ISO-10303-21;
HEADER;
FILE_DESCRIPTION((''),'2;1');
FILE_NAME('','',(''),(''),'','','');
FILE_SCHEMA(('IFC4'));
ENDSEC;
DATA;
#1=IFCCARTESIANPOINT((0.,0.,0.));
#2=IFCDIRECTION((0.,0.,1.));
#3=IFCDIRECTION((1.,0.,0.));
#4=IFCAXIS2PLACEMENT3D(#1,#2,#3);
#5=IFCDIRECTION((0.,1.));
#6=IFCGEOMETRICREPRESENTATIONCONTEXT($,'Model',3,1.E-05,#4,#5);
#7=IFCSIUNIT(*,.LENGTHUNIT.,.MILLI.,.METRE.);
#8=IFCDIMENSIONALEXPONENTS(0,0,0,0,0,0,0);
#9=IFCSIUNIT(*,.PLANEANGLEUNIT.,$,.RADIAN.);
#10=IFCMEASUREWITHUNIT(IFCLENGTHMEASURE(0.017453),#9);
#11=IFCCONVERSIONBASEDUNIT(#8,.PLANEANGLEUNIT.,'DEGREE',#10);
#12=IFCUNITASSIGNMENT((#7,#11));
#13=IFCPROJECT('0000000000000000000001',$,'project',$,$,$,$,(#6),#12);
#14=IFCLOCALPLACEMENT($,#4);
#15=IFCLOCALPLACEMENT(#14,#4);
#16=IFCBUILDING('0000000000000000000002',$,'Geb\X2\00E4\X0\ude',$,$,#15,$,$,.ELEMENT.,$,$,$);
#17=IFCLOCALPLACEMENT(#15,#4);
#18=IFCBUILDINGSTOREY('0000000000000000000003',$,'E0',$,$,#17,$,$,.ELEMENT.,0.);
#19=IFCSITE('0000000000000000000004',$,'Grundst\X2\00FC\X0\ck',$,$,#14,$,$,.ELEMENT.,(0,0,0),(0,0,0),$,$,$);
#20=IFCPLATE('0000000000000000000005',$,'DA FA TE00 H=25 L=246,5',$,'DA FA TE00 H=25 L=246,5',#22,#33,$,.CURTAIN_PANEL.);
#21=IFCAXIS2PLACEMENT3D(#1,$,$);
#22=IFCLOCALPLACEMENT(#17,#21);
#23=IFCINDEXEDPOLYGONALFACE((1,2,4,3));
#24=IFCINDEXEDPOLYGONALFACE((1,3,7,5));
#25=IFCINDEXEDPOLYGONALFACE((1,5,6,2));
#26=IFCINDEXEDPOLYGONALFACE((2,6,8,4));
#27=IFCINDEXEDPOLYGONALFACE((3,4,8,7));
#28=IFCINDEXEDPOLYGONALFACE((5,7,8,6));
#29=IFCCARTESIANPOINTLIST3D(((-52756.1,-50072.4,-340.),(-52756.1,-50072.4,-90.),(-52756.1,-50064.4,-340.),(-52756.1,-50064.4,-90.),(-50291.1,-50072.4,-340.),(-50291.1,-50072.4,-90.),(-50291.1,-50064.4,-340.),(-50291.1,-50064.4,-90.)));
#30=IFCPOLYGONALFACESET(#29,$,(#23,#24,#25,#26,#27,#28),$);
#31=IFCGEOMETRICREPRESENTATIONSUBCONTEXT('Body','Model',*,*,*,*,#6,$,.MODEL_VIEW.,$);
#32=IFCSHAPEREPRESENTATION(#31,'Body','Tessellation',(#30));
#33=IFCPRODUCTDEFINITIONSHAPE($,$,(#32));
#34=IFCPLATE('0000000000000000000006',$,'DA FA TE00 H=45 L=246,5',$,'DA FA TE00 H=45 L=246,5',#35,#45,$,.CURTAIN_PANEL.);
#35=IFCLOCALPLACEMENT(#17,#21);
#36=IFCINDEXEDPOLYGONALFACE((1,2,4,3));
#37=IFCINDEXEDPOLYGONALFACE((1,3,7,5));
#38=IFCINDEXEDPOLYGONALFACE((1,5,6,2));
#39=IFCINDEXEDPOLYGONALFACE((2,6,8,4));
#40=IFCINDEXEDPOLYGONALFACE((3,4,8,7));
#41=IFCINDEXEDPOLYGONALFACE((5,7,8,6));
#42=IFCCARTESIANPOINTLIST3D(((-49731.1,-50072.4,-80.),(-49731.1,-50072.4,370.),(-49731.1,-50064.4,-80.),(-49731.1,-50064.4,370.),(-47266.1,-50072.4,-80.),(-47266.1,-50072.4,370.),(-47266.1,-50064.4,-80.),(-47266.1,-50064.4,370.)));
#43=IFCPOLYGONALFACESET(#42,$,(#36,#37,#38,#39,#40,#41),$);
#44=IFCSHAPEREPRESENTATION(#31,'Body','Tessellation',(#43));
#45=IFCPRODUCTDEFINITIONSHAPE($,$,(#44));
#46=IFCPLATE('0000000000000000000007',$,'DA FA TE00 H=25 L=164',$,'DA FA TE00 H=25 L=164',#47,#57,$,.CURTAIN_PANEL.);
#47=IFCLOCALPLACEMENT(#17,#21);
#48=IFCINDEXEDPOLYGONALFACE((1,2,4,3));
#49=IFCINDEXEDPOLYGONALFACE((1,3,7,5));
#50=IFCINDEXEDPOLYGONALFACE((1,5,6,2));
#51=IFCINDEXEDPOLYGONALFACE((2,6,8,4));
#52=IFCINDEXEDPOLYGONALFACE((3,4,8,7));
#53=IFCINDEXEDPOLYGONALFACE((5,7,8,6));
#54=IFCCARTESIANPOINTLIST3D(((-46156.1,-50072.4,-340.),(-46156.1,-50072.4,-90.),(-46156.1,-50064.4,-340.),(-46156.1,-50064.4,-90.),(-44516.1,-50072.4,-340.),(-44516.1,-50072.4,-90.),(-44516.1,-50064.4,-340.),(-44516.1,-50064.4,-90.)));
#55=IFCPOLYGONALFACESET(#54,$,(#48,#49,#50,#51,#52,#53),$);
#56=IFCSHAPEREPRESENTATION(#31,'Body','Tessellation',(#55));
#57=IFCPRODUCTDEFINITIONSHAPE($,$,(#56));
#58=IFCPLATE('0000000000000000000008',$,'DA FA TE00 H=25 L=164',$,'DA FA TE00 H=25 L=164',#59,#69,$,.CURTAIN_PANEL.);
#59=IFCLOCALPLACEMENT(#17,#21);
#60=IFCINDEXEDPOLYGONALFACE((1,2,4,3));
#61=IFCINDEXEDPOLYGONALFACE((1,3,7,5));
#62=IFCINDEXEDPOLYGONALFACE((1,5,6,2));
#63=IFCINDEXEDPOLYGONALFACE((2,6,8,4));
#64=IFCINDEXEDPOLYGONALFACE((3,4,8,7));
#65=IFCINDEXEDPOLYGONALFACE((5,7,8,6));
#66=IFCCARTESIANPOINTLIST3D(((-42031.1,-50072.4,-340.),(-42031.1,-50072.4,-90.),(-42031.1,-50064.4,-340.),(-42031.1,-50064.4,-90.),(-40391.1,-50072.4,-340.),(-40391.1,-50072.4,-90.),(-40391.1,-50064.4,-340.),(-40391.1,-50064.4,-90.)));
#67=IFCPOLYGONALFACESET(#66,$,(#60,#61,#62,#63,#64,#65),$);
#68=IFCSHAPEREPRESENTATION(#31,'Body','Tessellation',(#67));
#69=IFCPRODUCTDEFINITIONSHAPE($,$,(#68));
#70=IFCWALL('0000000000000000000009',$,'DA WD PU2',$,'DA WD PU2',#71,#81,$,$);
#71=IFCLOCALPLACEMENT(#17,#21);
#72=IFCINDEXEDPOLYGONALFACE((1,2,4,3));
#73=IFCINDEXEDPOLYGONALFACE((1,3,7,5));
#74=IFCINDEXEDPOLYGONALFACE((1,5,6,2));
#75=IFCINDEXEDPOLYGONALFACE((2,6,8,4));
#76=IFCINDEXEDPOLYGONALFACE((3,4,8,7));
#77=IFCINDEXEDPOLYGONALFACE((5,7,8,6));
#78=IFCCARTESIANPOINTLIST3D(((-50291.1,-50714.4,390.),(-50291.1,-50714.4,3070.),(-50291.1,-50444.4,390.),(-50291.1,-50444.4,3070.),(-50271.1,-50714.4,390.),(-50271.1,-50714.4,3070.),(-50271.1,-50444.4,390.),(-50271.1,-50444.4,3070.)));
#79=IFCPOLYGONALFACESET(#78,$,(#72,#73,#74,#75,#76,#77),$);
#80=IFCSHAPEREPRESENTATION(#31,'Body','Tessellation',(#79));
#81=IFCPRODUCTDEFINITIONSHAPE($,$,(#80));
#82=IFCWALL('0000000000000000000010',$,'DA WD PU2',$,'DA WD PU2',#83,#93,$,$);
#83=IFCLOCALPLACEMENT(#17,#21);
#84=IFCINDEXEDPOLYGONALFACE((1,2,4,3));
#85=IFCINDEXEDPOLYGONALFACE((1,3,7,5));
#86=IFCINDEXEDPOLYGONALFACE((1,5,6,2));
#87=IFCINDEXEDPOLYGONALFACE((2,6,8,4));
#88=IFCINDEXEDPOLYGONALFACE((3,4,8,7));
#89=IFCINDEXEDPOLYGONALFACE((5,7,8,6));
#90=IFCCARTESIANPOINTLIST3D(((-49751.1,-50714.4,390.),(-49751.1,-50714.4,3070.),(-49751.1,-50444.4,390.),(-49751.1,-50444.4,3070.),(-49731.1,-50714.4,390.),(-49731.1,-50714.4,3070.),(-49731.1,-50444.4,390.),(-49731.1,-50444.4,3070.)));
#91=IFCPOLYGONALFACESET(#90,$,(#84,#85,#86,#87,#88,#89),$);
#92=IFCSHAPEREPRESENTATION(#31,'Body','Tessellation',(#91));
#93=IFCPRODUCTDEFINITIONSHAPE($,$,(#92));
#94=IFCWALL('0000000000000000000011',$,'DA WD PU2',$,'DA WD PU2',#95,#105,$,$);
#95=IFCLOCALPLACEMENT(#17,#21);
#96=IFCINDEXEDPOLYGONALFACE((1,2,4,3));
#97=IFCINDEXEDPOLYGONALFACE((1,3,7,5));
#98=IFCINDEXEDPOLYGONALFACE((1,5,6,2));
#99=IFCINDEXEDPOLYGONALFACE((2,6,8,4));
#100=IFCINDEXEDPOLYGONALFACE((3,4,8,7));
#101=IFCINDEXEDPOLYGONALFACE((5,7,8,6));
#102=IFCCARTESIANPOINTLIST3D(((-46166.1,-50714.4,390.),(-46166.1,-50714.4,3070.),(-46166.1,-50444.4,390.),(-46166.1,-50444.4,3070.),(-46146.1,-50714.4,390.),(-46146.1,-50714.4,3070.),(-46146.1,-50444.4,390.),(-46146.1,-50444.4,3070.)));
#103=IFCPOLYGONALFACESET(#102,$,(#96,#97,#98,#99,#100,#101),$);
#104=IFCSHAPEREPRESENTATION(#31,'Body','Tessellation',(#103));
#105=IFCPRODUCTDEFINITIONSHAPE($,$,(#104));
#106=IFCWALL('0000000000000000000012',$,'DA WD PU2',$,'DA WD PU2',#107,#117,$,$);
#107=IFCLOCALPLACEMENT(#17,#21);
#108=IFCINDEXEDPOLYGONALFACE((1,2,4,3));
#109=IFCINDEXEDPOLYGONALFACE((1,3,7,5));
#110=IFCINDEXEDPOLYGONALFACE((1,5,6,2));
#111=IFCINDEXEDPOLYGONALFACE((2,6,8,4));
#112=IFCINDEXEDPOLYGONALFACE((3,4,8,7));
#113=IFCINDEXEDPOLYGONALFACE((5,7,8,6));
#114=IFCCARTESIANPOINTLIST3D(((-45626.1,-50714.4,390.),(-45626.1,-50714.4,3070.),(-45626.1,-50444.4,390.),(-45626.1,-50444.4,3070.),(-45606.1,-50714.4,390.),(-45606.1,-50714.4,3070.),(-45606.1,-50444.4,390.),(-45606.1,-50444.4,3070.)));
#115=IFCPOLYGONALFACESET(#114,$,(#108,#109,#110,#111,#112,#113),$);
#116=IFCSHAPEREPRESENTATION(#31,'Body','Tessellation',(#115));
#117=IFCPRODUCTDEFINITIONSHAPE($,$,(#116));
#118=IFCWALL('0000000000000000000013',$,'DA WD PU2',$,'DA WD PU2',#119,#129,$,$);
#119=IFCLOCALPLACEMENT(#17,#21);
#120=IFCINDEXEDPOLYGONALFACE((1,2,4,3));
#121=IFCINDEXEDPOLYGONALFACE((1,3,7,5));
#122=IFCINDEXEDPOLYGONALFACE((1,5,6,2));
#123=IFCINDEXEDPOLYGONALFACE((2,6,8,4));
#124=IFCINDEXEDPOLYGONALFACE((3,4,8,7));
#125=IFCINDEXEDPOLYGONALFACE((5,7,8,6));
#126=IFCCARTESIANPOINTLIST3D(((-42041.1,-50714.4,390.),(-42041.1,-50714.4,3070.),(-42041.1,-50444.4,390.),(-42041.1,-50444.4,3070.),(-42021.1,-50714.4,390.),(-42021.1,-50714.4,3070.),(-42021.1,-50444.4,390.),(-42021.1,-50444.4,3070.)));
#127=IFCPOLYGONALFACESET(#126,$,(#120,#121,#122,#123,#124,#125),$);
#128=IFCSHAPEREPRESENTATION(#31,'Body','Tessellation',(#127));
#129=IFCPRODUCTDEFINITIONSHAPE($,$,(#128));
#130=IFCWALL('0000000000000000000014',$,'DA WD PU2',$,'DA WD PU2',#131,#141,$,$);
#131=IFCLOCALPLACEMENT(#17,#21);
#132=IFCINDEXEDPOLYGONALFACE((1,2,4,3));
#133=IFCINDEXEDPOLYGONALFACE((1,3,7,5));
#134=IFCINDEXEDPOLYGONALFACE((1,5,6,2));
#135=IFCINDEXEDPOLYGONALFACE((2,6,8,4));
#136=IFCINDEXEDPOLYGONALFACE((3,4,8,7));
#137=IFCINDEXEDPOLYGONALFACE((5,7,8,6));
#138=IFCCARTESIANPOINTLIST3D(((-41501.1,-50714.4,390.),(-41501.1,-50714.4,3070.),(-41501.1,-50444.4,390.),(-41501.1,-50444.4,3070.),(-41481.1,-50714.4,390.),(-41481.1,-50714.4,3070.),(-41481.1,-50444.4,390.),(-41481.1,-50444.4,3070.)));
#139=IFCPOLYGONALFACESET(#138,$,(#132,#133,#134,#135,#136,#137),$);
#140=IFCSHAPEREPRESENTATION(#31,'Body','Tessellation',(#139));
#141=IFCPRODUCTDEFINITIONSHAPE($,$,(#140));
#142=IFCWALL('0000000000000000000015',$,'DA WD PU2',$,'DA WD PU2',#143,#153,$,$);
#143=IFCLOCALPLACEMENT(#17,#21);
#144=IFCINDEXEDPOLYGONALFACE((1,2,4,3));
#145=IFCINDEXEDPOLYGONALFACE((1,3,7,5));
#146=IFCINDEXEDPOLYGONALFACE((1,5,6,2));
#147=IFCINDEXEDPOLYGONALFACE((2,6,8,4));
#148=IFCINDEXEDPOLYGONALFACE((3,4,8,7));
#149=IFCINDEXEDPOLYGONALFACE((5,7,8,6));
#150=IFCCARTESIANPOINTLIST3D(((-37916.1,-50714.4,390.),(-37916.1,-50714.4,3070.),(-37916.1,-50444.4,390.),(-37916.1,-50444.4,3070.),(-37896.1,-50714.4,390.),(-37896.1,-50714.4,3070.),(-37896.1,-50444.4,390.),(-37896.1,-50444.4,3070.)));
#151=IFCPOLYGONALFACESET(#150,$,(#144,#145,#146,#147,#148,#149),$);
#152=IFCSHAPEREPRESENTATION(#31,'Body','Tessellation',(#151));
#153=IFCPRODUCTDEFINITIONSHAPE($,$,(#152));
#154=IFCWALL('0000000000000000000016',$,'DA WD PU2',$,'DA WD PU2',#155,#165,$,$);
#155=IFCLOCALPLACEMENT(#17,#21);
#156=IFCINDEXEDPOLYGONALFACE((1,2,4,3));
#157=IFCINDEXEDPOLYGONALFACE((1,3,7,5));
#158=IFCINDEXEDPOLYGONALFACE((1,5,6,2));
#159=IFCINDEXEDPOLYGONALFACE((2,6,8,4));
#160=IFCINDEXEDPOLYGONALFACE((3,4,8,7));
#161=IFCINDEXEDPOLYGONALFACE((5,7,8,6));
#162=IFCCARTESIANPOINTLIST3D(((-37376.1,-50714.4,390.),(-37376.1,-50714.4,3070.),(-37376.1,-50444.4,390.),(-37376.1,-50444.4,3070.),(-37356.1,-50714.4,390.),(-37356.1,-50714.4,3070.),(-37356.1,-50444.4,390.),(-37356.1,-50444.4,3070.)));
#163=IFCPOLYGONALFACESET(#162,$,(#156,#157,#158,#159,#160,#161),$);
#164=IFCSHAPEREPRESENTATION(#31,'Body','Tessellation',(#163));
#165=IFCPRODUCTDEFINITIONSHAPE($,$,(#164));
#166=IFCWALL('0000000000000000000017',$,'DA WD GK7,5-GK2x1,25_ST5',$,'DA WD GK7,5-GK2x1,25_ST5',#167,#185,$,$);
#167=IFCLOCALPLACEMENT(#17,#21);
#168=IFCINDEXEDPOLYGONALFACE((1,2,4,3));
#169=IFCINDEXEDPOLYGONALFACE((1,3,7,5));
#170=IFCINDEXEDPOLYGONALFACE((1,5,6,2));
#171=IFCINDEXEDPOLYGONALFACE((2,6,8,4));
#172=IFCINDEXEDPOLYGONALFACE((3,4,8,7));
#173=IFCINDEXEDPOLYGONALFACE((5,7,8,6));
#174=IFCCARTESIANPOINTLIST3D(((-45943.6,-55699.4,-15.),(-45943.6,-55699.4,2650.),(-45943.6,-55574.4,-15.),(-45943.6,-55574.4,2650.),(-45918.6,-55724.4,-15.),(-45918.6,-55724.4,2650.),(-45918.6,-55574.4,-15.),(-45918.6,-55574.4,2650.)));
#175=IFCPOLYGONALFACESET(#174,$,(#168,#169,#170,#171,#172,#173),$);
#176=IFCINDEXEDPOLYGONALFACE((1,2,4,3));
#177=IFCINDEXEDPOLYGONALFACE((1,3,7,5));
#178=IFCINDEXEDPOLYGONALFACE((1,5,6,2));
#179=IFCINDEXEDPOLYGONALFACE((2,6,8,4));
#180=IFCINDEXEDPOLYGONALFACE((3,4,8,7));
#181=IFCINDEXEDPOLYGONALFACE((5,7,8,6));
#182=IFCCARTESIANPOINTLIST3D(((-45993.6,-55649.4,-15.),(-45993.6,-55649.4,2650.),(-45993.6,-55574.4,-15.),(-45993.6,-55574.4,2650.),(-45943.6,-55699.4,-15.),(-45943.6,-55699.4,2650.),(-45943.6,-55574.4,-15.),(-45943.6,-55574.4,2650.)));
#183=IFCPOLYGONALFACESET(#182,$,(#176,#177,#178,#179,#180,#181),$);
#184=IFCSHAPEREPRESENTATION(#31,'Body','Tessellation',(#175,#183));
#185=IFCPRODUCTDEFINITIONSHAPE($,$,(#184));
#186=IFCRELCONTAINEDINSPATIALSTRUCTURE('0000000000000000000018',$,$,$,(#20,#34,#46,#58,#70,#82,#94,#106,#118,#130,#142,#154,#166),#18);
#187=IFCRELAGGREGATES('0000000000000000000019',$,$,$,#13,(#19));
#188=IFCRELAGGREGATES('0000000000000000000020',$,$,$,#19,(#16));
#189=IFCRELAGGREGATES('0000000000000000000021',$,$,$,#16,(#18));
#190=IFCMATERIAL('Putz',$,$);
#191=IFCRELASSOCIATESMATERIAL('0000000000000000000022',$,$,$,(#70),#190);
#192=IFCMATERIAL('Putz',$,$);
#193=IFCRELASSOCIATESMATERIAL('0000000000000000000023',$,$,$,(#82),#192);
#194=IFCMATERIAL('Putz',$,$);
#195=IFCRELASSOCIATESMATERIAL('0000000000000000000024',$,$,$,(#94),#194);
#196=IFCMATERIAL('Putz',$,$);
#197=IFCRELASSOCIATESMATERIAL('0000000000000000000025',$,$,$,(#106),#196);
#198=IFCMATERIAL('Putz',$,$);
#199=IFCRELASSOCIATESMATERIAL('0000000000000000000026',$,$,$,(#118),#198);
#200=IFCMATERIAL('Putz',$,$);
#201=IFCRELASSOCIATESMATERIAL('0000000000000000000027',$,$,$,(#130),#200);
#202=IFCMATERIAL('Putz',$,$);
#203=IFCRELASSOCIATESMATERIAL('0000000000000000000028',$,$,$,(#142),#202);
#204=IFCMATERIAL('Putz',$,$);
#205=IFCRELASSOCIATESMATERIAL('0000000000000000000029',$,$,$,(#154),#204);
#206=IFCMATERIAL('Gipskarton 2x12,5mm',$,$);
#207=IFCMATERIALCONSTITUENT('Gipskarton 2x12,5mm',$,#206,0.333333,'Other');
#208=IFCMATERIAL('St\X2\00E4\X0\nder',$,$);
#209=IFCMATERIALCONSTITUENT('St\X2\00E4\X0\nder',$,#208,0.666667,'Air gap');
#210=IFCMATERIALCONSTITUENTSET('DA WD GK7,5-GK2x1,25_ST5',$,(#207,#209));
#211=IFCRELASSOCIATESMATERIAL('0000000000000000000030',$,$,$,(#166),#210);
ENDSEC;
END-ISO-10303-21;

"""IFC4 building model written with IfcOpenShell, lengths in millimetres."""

from ifc_helpers import new_model, entity, si_unit, converted_unit, direction, frame, origin_with_axes, place, context, subcontext, project, spatial, line, indexed_curve, outline, extrude, source, transform, mapped, material, constituent, constituent_set, element, save


model = new_model("IFC4")

# Units and contexts
model_context = context("Model", 3, precision=1e-05, world=origin_with_axes(), true_north=direction((0.0, 1.0)))
body_context = subcontext(model_context, "Body", "Model", "MODEL_VIEW")
ifc_project = project(units=[si_unit("LENGTHUNIT", "METRE", prefix="MILLI"), converted_unit("PLANEANGLEUNIT", "DEGREE", entity("IfcLengthMeasure", 0.017453), si_unit("PLANEANGLEUNIT", "RADIAN"), dimensions=[0, 0, 0, 0, 0, 0, 0])], contexts=[model_context])

# Site, building, storey
site_placement = place(None, origin_with_axes())
site = spatial("IfcSite", under=ifc_project, at=site_placement, Name="Grundstück", CompositionType="ELEMENT", RefLatitude=(0, 0, 0), RefLongitude=(0, 0, 0))
building_placement = place(site_placement, origin_with_axes())
building = spatial("IfcBuilding", under=site, at=building_placement, Name="Gebäude", CompositionType="ELEMENT")
storey_placement = place(building_placement, origin_with_axes())
storey = spatial("IfcBuildingStorey", under=building, at=storey_placement, Name="E0", CompositionType="ELEMENT", Elevation=0.0)

# Plates
shared_shape_1 = source(origin_with_axes(), body_context, "Body", "SweptSolid", [
    extrude(outline(indexed_curve([(-1232.5, 0.0), (1232.5, 0.0), (1232.5, 8.0), (-1232.5, 8.0)], segments=[line(1, 2), line(2, 3), line(3, 4), line(4, 1)])), frame((0.0, 0.0, 250.0), z_axis=(0.0, 0.0, 1.0), x_axis=(1.0, 0.0, 0.0)), (0.0, 0.0, -1.0), 250.0),
])
plate_1_placement = place(storey_placement, frame((-51523.6, -50064.4, -340.0), z_axis=(0.0, 0.0, 1.0), x_axis=(-1.0, 0.0, 0.0)))
element("IfcPlate", 1, at=plate_1_placement, inside=storey, Name="DA FA TE00 H=25 L=246,5", ObjectType="DA FA TE00 H=25 L=246,5", PredefinedType="CURTAIN_PANEL", context=body_context, shape_type="MappedRepresentation", body=[
    mapped(shared_shape_1, transform((0.0, 0.0, 0.0), x_axis=(1.0, 0.0, 0.0), y_axis=(0.0, 1.0, 0.0), z_axis=(0.0, 0.0, 1.0), scale=1.0)),
])
shared_shape_2 = source(origin_with_axes(), body_context, "Body", "SweptSolid", [
    extrude(outline(indexed_curve([(-1232.5, 0.0), (1232.5, 0.0), (1232.5, 8.0), (-1232.5, 8.0)], segments=[line(1, 2), line(2, 3), line(3, 4), line(4, 1)])), frame((0.0, 0.0, 450.0), z_axis=(0.0, 0.0, 1.0), x_axis=(1.0, 0.0, 0.0)), (0.0, 0.0, -1.0), 450.0),
])
plate_2_placement = place(storey_placement, frame((-48498.6, -50064.4, -80.0), z_axis=(0.0, 0.0, 1.0), x_axis=(-1.0, 0.0, 0.0)))
element("IfcPlate", 2, at=plate_2_placement, inside=storey, Name="DA FA TE00 H=45 L=246,5", ObjectType="DA FA TE00 H=45 L=246,5", PredefinedType="CURTAIN_PANEL", context=body_context, shape_type="MappedRepresentation", body=[
    mapped(shared_shape_2, transform((0.0, 0.0, 0.0), x_axis=(1.0, 0.0, 0.0), y_axis=(0.0, 1.0, 0.0), z_axis=(0.0, 0.0, 1.0), scale=1.0)),
])
shared_shape_3 = source(origin_with_axes(), body_context, "Body", "SweptSolid", [
    extrude(outline(indexed_curve([(-820.0, 0.0), (820.0, 0.0), (820.0, 8.0), (-820.0, 8.0)], segments=[line(1, 2), line(2, 3), line(3, 4), line(4, 1)])), frame((0.0, 0.0, 250.0), z_axis=(0.0, 0.0, 1.0), x_axis=(1.0, 0.0, 0.0)), (0.0, 0.0, -1.0), 250.0),
])
for number, where, z_axis, x_axis, name in (
    (3, (-45336.1, -50064.4, -340.0), (0.0, 0.0, 1.0), (-1.0, 0.0, 0.0), "DA FA TE00 H=25 L=164"),
    (4, (-41211.1, -50064.4, -340.0), (0.0, 0.0, 1.0), (-1.0, 0.0, 0.0), "DA FA TE00 H=25 L=164"),
):
    element("IfcPlate", number, at=place(storey_placement, frame(where, z_axis=z_axis, x_axis=x_axis)), inside=storey, Name=name, ObjectType="DA FA TE00 H=25 L=164", PredefinedType="CURTAIN_PANEL", context=body_context, shape_type="MappedRepresentation", body=[
        mapped(shared_shape_3, transform((0.0, 0.0, 0.0), x_axis=(1.0, 0.0, 0.0), y_axis=(0.0, 1.0, 0.0), z_axis=(0.0, 0.0, 1.0), scale=1.0)),
    ])

# Walls
ifc_material_1 = material(Name="Putz")
wall_1_placement = place(storey_placement, frame((-50281.1, -50714.4, 390.0), z_axis=(0.0, 0.0, 1.0), x_axis=(0.0, 1.0, 0.0)))
element("IfcWall", 5, at=wall_1_placement, inside=storey, material=ifc_material_1, Name="DA WD PU2", ObjectType="DA WD PU2", context=body_context, shape_type="SweptSolid", body=[
    extrude(outline(indexed_curve([(0.0, -10.0), (0.0, 10.0), (270.0, 10.0), (270.0, -10.0)], segments=[line(1, 2), line(2, 3), line(3, 4), line(4, 1)])), origin_with_axes(), (0.0, 0.0, 1.0), 2680.0),
])
ifc_material_2 = material(Name="Putz")
wall_2_placement = place(storey_placement, frame((-49741.1, -50714.4, 390.0), z_axis=(0.0, 0.0, 1.0), x_axis=(0.0, 1.0, 0.0)))
element("IfcWall", 6, at=wall_2_placement, inside=storey, material=ifc_material_2, Name="DA WD PU2", ObjectType="DA WD PU2", context=body_context, shape_type="SweptSolid", body=[
    extrude(outline(indexed_curve([(0.0, -10.0), (0.0, 10.0), (270.0, 10.0), (270.0, -10.0)], segments=[line(1, 2), line(2, 3), line(3, 4), line(4, 1)])), origin_with_axes(), (0.0, 0.0, 1.0), 2680.0),
])
ifc_material_3 = material(Name="Putz")
wall_3_placement = place(storey_placement, frame((-46156.1, -50714.4, 390.0), z_axis=(0.0, 0.0, 1.0), x_axis=(0.0, 1.0, 0.0)))
element("IfcWall", 7, at=wall_3_placement, inside=storey, material=ifc_material_3, Name="DA WD PU2", ObjectType="DA WD PU2", context=body_context, shape_type="SweptSolid", body=[
    extrude(outline(indexed_curve([(0.0, -10.0), (0.0, 10.0), (270.0, 10.0), (270.0, -10.0)], segments=[line(1, 2), line(2, 3), line(3, 4), line(4, 1)])), origin_with_axes(), (0.0, 0.0, 1.0), 2680.0),
])
ifc_material_4 = material(Name="Putz")
wall_4_placement = place(storey_placement, frame((-45616.1, -50714.4, 390.0), z_axis=(0.0, 0.0, 1.0), x_axis=(0.0, 1.0, 0.0)))
element("IfcWall", 8, at=wall_4_placement, inside=storey, material=ifc_material_4, Name="DA WD PU2", ObjectType="DA WD PU2", context=body_context, shape_type="SweptSolid", body=[
    extrude(outline(indexed_curve([(0.0, -10.0), (0.0, 10.0), (270.0, 10.0), (270.0, -10.0)], segments=[line(1, 2), line(2, 3), line(3, 4), line(4, 1)])), origin_with_axes(), (0.0, 0.0, 1.0), 2680.0),
])
ifc_material_5 = material(Name="Putz")
wall_5_placement = place(storey_placement, frame((-42031.1, -50714.4, 390.0), z_axis=(0.0, 0.0, 1.0), x_axis=(0.0, 1.0, 0.0)))
element("IfcWall", 9, at=wall_5_placement, inside=storey, material=ifc_material_5, Name="DA WD PU2", ObjectType="DA WD PU2", context=body_context, shape_type="SweptSolid", body=[
    extrude(outline(indexed_curve([(0.0, -10.0), (0.0, 10.0), (270.0, 10.0), (270.0, -10.0)], segments=[line(1, 2), line(2, 3), line(3, 4), line(4, 1)])), origin_with_axes(), (0.0, 0.0, 1.0), 2680.0),
])
ifc_material_6 = material(Name="Putz")
wall_6_placement = place(storey_placement, frame((-41491.1, -50714.4, 390.0), z_axis=(0.0, 0.0, 1.0), x_axis=(0.0, 1.0, 0.0)))
element("IfcWall", 10, at=wall_6_placement, inside=storey, material=ifc_material_6, Name="DA WD PU2", ObjectType="DA WD PU2", context=body_context, shape_type="SweptSolid", body=[
    extrude(outline(indexed_curve([(0.0, -10.0), (0.0, 10.0), (270.0, 10.0), (270.0, -10.0)], segments=[line(1, 2), line(2, 3), line(3, 4), line(4, 1)])), origin_with_axes(), (0.0, 0.0, 1.0), 2680.0),
])
ifc_material_7 = material(Name="Putz")
wall_7_placement = place(storey_placement, frame((-37906.1, -50714.4, 390.0), z_axis=(0.0, 0.0, 1.0), x_axis=(0.0, 1.0, 0.0)))
element("IfcWall", 11, at=wall_7_placement, inside=storey, material=ifc_material_7, Name="DA WD PU2", ObjectType="DA WD PU2", context=body_context, shape_type="SweptSolid", body=[
    extrude(outline(indexed_curve([(0.0, -10.0), (0.0, 10.0), (270.0, 10.0), (270.0, -10.0)], segments=[line(1, 2), line(2, 3), line(3, 4), line(4, 1)])), origin_with_axes(), (0.0, 0.0, 1.0), 2680.0),
])
ifc_material_8 = material(Name="Putz")
wall_8_placement = place(storey_placement, frame((-37366.1, -50714.4, 390.0), z_axis=(0.0, 0.0, 1.0), x_axis=(0.0, 1.0, 0.0)))
element("IfcWall", 12, at=wall_8_placement, inside=storey, material=ifc_material_8, Name="DA WD PU2", ObjectType="DA WD PU2", context=body_context, shape_type="SweptSolid", body=[
    extrude(outline(indexed_curve([(0.0, -10.0), (0.0, 10.0), (270.0, 10.0), (270.0, -10.0)], segments=[line(1, 2), line(2, 3), line(3, 4), line(4, 1)])), origin_with_axes(), (0.0, 0.0, 1.0), 2680.0),
])
ifc_material_9 = material(Name="Gipskarton 2x12,5mm")
ifc_constituent_1 = constituent(ifc_material_9, Name="Gipskarton 2x12,5mm", Category="Other", fraction=0.333333)
ifc_material_10 = material(Name="Ständer")
ifc_constituent_2 = constituent(ifc_material_10, Name="Ständer", Category="Air gap", fraction=0.666667)
ifc_constituent_set_1 = constituent_set(constituents=[ifc_constituent_1, ifc_constituent_2], Name="DA WD GK7,5-GK2x1,25_ST5")
wall_9_placement = place(storey_placement, frame((-45956.1, -55574.4, -15.0), z_axis=(0.0, 0.0, 1.0), x_axis=(0.0, -1.0, 0.0)))
element("IfcWall", 13, at=wall_9_placement, inside=storey, material=ifc_constituent_set_1, Name="DA WD GK7,5-GK2x1,25_ST5", ObjectType="DA WD GK7,5-GK2x1,25_ST5", context=body_context, shape_type="SweptSolid", body=[
    extrude(outline(indexed_curve([(0.0, 37.5), (150.0, 37.5), (125.0, 12.5), (0.0, 12.5)], segments=[line(1, 2), line(2, 3), line(3, 4), line(4, 1)])), origin_with_axes(), (0.0, 0.0, 1.0), 2665.0),
    extrude(outline(indexed_curve([(0.0, 12.5), (125.0, 12.5), (75.0, -37.5), (0.0, -37.5)], segments=[line(1, 2), line(2, 3), line(3, 4), line(4, 1)])), origin_with_axes(), (0.0, 0.0, 1.0), 2665.0),
])

save(model, "model.ifc")
